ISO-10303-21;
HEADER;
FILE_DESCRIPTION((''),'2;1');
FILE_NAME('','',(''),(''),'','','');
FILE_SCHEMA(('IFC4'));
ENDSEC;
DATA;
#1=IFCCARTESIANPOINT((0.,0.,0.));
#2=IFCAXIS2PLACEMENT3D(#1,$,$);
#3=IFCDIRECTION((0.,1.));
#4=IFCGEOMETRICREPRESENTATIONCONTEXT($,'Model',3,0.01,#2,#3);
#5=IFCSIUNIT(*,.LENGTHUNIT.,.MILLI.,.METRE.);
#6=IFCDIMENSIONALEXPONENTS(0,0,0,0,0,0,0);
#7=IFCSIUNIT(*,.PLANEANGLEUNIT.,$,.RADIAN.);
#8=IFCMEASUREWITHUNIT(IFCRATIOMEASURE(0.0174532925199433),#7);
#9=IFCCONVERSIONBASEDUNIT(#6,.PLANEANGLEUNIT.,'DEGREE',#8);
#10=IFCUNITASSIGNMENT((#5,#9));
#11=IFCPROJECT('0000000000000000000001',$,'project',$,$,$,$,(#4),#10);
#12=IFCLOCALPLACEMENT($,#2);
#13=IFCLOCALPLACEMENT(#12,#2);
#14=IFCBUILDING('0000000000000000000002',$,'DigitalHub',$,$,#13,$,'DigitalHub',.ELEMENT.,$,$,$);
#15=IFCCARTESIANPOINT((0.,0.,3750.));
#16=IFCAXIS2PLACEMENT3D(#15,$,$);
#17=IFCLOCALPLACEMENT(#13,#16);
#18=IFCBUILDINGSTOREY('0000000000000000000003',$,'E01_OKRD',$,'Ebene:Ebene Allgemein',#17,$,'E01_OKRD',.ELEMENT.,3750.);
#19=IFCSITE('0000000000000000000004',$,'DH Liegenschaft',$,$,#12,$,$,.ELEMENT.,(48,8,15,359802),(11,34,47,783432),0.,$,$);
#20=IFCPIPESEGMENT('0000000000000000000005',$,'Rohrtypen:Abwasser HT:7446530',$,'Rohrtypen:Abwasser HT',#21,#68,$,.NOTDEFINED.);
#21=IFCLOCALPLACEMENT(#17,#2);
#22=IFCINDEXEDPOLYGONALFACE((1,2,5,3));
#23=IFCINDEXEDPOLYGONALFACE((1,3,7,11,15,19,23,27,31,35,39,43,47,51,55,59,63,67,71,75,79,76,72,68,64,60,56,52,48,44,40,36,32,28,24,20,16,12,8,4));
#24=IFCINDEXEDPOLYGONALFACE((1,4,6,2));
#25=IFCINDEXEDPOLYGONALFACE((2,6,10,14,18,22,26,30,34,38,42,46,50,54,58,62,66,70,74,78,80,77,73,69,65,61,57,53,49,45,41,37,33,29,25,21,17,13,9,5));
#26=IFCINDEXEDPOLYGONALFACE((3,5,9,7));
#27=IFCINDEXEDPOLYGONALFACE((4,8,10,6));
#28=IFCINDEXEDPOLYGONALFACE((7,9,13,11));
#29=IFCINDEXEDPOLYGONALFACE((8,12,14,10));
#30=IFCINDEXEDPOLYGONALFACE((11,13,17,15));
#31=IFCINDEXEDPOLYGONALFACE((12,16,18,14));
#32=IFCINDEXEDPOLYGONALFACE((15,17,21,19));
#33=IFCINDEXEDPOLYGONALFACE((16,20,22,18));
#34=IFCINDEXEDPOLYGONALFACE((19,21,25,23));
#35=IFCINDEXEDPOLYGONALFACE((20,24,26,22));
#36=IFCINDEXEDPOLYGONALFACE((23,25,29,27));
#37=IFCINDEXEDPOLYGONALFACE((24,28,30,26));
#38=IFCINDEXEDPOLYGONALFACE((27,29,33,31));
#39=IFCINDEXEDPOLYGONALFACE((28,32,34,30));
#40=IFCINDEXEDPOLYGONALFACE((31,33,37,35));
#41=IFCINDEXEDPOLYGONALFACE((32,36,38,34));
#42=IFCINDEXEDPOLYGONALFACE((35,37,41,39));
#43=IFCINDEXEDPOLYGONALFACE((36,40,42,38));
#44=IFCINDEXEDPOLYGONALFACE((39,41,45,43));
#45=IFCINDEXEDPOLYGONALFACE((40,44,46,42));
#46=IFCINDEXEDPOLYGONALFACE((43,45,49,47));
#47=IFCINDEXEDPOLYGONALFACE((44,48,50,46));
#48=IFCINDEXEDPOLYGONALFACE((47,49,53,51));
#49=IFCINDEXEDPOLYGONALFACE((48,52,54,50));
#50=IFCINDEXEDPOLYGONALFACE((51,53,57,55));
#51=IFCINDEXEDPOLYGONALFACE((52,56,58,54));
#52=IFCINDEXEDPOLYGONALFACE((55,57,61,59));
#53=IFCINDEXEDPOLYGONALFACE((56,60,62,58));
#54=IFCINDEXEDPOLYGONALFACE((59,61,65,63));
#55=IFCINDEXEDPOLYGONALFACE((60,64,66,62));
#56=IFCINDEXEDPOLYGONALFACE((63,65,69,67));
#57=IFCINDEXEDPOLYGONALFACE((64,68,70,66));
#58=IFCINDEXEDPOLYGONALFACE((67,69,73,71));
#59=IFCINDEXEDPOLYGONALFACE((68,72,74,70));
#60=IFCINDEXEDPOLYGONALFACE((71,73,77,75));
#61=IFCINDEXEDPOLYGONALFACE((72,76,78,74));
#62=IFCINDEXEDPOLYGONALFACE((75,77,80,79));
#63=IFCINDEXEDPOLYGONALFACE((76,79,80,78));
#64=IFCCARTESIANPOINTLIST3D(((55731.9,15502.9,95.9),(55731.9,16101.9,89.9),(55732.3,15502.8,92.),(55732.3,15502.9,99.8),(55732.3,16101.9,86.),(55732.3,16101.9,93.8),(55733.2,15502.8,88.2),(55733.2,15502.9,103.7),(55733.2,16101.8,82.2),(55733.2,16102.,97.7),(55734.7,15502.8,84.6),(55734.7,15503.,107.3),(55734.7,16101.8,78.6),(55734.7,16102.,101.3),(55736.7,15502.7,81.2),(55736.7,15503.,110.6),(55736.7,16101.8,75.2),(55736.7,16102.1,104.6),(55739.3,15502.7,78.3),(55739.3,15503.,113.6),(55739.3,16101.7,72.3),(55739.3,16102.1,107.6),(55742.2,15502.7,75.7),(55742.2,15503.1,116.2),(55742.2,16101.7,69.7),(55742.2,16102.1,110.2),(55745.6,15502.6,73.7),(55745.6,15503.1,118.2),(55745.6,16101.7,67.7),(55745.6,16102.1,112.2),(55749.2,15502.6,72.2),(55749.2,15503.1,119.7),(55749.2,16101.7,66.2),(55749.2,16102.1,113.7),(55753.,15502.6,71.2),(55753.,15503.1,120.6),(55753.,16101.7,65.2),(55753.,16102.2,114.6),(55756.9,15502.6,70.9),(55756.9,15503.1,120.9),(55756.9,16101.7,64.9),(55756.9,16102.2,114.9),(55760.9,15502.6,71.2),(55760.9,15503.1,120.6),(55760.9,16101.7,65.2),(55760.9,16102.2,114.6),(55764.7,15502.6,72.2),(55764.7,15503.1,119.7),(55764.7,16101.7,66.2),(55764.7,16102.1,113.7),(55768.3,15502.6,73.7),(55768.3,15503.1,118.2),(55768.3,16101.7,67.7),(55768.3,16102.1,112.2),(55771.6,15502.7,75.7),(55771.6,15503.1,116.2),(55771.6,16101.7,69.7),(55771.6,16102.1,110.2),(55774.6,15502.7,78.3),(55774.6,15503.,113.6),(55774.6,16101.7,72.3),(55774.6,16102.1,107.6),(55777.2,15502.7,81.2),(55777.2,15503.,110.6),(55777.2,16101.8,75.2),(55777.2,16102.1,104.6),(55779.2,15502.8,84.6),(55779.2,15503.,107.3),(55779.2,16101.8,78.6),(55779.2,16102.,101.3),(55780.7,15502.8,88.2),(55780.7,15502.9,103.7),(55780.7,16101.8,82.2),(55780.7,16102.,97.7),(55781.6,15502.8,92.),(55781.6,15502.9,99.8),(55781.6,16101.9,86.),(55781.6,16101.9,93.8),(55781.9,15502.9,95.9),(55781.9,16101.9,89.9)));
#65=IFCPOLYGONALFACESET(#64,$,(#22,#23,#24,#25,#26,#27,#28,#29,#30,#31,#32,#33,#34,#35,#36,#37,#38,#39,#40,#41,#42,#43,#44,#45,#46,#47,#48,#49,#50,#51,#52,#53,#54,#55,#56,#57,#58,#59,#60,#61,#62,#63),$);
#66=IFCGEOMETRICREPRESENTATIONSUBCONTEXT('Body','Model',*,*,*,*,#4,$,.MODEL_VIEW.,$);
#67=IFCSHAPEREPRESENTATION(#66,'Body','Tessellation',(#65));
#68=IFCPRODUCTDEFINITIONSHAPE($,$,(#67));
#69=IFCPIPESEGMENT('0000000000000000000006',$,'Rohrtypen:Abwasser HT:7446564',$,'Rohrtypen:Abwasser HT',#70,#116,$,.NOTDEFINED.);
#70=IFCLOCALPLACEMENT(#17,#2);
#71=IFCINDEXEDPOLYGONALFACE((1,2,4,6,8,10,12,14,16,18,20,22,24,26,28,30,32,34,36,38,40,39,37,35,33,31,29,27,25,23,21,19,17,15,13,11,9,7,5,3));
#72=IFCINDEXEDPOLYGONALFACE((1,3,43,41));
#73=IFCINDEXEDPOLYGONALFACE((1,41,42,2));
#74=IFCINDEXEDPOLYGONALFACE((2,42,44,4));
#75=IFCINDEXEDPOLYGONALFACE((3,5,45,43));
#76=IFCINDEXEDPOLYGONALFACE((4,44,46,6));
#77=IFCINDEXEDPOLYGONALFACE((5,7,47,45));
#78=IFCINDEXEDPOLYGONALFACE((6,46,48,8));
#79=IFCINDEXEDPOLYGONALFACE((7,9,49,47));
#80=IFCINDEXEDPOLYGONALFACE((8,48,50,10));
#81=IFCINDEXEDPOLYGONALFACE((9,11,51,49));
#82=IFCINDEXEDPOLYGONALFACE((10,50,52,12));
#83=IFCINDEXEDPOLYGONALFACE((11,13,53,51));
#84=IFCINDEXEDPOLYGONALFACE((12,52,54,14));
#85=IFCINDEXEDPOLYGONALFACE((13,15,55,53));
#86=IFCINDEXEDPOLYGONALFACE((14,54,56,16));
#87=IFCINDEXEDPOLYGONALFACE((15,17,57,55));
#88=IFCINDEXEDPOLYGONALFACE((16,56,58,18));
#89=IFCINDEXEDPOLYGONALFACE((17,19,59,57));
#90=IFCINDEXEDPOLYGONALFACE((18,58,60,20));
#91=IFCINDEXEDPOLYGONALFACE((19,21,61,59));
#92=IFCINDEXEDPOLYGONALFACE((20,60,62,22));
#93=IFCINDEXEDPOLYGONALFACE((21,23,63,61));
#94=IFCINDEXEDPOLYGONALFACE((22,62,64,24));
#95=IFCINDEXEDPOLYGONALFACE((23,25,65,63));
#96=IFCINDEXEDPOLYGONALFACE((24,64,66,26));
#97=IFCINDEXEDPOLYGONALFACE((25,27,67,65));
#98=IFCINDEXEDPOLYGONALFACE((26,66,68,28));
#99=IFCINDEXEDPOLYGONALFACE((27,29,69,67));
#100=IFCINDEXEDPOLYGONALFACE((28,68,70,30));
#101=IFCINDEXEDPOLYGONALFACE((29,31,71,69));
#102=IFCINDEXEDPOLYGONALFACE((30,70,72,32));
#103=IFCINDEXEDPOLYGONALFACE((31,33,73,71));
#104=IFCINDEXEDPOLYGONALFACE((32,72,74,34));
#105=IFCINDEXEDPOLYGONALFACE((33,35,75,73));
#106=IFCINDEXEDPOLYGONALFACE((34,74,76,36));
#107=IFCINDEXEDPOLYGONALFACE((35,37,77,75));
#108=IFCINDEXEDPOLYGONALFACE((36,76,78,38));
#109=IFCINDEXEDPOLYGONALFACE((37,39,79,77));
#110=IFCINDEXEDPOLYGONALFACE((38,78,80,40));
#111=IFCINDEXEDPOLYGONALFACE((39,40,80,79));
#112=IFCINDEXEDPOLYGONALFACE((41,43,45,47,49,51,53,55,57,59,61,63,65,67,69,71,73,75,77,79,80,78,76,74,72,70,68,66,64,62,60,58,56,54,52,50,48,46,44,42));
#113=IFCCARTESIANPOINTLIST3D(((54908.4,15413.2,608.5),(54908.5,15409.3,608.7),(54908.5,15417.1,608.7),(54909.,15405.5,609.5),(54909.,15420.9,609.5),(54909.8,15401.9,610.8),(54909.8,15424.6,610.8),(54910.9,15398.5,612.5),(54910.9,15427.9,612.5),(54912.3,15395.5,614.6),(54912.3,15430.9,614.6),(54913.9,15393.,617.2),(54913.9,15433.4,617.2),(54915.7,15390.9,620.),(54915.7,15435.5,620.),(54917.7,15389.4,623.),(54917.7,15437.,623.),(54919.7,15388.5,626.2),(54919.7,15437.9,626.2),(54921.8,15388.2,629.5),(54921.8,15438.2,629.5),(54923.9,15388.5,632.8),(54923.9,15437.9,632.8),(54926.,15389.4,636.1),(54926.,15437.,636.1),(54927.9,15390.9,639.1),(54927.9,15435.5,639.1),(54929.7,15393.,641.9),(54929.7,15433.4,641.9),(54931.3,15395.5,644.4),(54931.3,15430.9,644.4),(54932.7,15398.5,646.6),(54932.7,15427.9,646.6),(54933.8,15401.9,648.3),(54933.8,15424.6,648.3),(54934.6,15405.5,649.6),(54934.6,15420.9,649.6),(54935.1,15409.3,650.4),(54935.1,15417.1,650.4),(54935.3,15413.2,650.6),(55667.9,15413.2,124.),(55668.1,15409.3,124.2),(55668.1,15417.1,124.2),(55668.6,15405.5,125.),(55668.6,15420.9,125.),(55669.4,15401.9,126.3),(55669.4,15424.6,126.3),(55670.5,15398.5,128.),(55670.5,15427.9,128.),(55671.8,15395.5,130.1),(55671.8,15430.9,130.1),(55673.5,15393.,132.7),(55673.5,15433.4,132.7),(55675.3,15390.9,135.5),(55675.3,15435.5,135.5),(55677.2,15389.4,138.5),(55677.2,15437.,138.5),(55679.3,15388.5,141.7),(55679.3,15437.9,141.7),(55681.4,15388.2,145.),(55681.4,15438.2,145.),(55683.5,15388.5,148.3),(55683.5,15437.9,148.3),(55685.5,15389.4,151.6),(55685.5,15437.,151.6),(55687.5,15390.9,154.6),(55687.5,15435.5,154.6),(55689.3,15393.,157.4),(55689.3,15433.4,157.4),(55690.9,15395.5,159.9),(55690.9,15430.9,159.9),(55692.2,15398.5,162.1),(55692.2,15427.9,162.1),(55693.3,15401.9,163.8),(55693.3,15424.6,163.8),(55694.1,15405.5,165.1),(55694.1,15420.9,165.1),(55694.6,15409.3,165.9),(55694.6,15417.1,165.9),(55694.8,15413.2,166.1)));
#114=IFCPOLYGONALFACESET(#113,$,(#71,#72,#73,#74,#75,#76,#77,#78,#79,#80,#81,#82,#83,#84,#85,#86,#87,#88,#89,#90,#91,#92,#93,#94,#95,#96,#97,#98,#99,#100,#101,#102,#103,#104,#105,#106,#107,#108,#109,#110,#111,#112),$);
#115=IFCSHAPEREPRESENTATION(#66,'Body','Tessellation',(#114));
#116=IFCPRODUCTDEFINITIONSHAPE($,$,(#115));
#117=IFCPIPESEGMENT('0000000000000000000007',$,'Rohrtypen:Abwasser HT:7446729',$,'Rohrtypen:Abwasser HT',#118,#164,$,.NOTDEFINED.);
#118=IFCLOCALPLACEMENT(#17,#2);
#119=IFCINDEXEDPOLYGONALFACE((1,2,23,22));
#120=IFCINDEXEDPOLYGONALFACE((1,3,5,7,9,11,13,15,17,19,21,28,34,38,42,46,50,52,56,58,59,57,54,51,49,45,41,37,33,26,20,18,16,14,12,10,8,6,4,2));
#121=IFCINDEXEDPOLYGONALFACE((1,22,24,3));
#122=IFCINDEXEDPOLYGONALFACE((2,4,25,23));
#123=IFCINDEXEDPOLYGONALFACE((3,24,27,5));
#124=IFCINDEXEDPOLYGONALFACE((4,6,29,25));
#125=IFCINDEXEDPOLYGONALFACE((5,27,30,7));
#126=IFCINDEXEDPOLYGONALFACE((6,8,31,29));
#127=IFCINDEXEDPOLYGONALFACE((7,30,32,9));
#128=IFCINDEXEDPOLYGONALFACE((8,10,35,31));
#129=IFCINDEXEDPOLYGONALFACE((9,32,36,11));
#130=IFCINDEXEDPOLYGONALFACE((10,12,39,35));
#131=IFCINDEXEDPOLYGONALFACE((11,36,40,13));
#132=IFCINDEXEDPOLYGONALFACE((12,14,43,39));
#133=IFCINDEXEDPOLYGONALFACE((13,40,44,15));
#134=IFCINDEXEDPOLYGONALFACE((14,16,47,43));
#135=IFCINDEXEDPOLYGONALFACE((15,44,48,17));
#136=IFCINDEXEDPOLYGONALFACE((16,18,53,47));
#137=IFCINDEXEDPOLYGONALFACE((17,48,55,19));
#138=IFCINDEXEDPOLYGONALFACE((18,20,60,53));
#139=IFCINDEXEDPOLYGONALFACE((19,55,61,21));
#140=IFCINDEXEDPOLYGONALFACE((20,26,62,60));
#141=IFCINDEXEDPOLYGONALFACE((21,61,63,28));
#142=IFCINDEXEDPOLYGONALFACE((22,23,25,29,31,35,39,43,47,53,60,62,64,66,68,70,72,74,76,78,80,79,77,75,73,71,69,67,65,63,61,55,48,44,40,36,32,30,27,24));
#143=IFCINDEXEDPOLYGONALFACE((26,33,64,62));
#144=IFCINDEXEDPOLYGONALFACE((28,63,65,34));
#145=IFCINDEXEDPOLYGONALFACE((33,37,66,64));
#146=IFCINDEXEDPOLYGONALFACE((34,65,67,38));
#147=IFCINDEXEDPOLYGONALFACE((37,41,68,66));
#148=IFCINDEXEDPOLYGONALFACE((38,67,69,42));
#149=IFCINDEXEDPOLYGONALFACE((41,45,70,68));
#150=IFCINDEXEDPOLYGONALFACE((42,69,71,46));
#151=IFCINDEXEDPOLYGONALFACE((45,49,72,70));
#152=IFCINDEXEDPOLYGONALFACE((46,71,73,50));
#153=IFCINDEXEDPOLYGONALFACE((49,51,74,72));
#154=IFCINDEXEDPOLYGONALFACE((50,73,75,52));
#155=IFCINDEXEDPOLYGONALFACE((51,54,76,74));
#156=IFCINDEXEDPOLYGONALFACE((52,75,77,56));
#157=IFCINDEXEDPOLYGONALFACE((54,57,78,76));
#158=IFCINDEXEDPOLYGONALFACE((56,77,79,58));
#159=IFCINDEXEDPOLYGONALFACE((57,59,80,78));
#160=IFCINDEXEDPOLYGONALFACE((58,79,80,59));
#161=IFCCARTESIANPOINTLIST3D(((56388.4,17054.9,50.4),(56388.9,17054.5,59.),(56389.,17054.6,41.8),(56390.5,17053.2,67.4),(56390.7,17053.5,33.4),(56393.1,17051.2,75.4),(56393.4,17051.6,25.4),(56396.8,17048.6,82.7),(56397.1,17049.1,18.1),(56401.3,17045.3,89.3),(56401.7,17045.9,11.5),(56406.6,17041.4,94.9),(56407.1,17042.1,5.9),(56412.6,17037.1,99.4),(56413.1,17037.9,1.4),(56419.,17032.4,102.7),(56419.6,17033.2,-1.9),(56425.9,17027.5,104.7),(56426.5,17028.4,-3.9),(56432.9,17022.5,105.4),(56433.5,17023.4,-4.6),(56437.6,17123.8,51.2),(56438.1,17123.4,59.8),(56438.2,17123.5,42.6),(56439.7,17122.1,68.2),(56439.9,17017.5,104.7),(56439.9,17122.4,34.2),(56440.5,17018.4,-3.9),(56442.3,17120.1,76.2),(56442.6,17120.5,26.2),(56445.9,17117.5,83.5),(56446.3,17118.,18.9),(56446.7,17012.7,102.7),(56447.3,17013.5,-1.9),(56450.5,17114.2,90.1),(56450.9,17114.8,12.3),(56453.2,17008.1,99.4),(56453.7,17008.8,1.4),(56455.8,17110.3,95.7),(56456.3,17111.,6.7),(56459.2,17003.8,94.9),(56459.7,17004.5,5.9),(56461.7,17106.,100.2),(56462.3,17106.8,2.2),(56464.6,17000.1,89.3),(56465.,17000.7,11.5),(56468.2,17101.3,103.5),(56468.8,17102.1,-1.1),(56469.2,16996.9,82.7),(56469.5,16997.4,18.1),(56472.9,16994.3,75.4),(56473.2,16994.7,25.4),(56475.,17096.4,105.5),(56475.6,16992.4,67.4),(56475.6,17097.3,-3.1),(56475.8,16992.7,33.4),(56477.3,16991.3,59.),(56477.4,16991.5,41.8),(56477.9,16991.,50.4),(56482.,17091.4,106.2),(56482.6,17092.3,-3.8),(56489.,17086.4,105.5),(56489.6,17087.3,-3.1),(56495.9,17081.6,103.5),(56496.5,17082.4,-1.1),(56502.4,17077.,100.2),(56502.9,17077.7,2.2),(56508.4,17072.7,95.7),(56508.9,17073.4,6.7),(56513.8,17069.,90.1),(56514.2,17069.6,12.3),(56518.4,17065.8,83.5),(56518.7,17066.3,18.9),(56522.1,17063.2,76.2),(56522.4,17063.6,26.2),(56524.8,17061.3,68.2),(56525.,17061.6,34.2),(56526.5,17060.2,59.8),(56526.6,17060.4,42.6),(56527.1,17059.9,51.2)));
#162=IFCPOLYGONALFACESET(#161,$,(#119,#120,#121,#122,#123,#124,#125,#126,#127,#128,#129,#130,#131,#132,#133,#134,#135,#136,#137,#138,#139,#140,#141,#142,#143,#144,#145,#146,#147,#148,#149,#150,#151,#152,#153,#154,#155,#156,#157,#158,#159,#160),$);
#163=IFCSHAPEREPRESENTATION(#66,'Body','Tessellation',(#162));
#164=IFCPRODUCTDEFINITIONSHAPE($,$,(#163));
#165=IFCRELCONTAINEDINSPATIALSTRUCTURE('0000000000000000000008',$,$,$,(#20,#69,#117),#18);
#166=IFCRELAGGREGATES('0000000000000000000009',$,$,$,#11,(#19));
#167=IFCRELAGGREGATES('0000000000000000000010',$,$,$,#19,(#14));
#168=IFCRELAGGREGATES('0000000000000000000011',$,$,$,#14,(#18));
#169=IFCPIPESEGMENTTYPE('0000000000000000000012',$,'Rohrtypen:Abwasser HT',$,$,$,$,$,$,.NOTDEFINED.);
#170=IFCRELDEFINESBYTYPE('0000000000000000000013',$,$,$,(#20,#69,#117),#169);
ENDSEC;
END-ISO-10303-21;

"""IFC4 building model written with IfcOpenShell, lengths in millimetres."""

from ifc_helpers import new_model, entity, si_unit, converted_unit, direction, frame, origin, place, context, subcontext, project, spatial, indexed_curve, outline, extrude, type_object, element, save


model = new_model("IFC4")

# Units and contexts
model_context = context("Model", 3, precision=0.01, world=origin(), true_north=direction((0.0, 1.0)))
body_context = subcontext(model_context, "Body", "Model", "MODEL_VIEW")
ifc_project = project(units=[si_unit("LENGTHUNIT", "METRE", prefix="MILLI"), converted_unit("PLANEANGLEUNIT", "DEGREE", entity("IfcRatioMeasure", 0.0174532925199433), si_unit("PLANEANGLEUNIT", "RADIAN"), dimensions=[0, 0, 0, 0, 0, 0, 0])], contexts=[model_context])

# Site, building, storey
site_placement = place(None, origin())
site = spatial("IfcSite", under=ifc_project, at=site_placement, Name="DH Liegenschaft", CompositionType="ELEMENT", RefLatitude=(48, 8, 15, 359802), RefLongitude=(11, 34, 47, 783432), RefElevation=0.0)
building_placement = place(site_placement, origin())
building = spatial("IfcBuilding", under=site, at=building_placement, Name="DigitalHub", LongName="DigitalHub", CompositionType="ELEMENT")
storey_placement = place(building_placement, frame((0.0, 0.0, 3750.0)))
storey = spatial("IfcBuildingStorey", under=building, at=storey_placement, Name="E01_OKRD", ObjectType="Ebene:Ebene Allgemein", LongName="E01_OKRD", CompositionType="ELEMENT", Elevation=3750.0)

# Pipe segments
pipe_segment_type_1 = type_object("IfcPipeSegmentType", Name="Rohrtypen:Abwasser HT", PredefinedType="NOTDEFINED")
pipe_segment_1_placement = place(storey_placement, frame((55730.3, 15501.0, 63.3)))
element("IfcPipeSegment", 1, at=pipe_segment_1_placement, inside=storey, type_object=pipe_segment_type_1, Name="Rohrtypen:Abwasser HT:7446530", ObjectType="Rohrtypen:Abwasser HT", PredefinedType="NOTDEFINED", context=body_context, shape_type="SweptSolid", body=[
    extrude(outline(indexed_curve([(25.0, 0.0), (24.7, 3.9), (23.8, 7.7), (22.3, 11.3), (20.2, 14.7), (17.7, 17.7), (14.7, 20.2), (11.3, 22.3), (7.7, 23.8), (3.9, 24.7), (0.0, 25.0), (-3.9, 24.7), (-7.7, 23.8), (-11.3, 22.3), (-14.7, 20.2), (-17.7, 17.7), (-20.2, 14.7), (-22.3, 11.3), (-23.8, 7.7), (-24.7, 3.9), (-25.0, 0.0), (-24.7, -3.9), (-23.8, -7.7), (-22.3, -11.3), (-20.2, -14.7), (-17.7, -17.7), (-14.7, -20.2), (-11.3, -22.3), (-7.7, -23.8), (-3.9, -24.7), (0.0, -25.0), (3.9, -24.7), (7.7, -23.8), (11.3, -22.3), (14.7, -20.2), (17.7, -17.7), (20.2, -14.7), (22.3, -11.3), (23.8, -7.7), (24.7, -3.9), (25.0, 0.0)], self_intersect=False)), frame((26.6, 1.8, 32.6), z_axis=(0.0, 0.99995, -0.010016), x_axis=(-1.0, 0.0, 0.0)), (0.0, 0.0, 1.0), 599.1),
])
pipe_segment_2_placement = place(storey_placement, frame((54906.8, 15386.6, 122.4)))
element("IfcPipeSegment", 2, at=pipe_segment_2_placement, inside=storey, type_object=pipe_segment_type_1, Name="Rohrtypen:Abwasser HT:7446564", ObjectType="Rohrtypen:Abwasser HT", PredefinedType="NOTDEFINED", context=body_context, shape_type="SweptSolid", body=[
    extrude(outline(indexed_curve([(25.0, 0.0), (24.7, 3.9), (23.8, 7.7), (22.3, 11.3), (20.2, 14.7), (17.7, 17.7), (14.7, 20.2), (11.3, 22.3), (7.7, 23.8), (3.9, 24.7), (0.0, 25.0), (-3.9, 24.7), (-7.7, 23.8), (-11.3, 22.3), (-14.7, 20.2), (-17.7, 17.7), (-20.2, 14.7), (-22.3, 11.3), (-23.8, 7.7), (-24.7, 3.9), (-25.0, 0.0), (-24.7, -3.9), (-23.8, -7.7), (-22.3, -11.3), (-20.2, -14.7), (-17.7, -17.7), (-14.7, -20.2), (-11.3, -22.3), (-7.7, -23.8), (-3.9, -24.7), (0.0, -25.0), (3.9, -24.7), (7.7, -23.8), (11.3, -22.3), (14.7, -20.2), (17.7, -17.7), (20.2, -14.7), (22.3, -11.3), (23.8, -7.7), (24.7, -3.9), (25.0, 0.0)], self_intersect=False)), frame((774.6, 26.6, 22.7), z_axis=(-0.843081, 0.0, 0.537787), x_axis=(0.0, 1.0, 0.0)), (0.0, 0.0, 1.0), 900.9),
])
pipe_segment_3_placement = place(storey_placement, frame((56386.8, 16989.4, -6.2)))
element("IfcPipeSegment", 3, at=pipe_segment_3_placement, inside=storey, type_object=pipe_segment_type_1, Name="Rohrtypen:Abwasser HT:7446729", ObjectType="Rohrtypen:Abwasser HT", PredefinedType="NOTDEFINED", context=body_context, shape_type="SweptSolid", body=[
    extrude(outline(indexed_curve([(55.0, 0.0), (54.3, 8.6), (52.3, 17.0), (49.0, 25.0), (44.5, 32.3), (38.9, 38.9), (32.3, 44.5), (25.0, 49.0), (17.0, 52.3), (8.6, 54.3), (0.0, 55.0), (-8.6, 54.3), (-17.0, 52.3), (-25.0, 49.0), (-32.3, 44.5), (-38.9, 38.9), (-44.5, 32.3), (-49.0, 25.0), (-52.3, 17.0), (-54.3, 8.6), (-55.0, 0.0), (-54.3, -8.6), (-52.3, -17.0), (-49.0, -25.0), (-44.5, -32.3), (-38.9, -38.9), (-32.3, -44.5), (-25.0, -49.0), (-17.0, -52.3), (-8.6, -54.3), (0.0, -55.0), (8.6, -54.3), (17.0, -52.3), (25.0, -49.0), (32.3, -44.5), (38.9, -38.9), (44.5, -32.3), (49.0, -25.0), (52.3, -17.0), (54.3, -8.6), (55.0, 0.0)], self_intersect=False)), frame((46.4, 33.6, 56.6), z_axis=(0.581002, 0.813847, 0.009483), x_axis=(-0.813884, 0.581028, 0.0)), (0.0, 0.0, 1.0), 84.7),
])

save(model, "model.ifc")
